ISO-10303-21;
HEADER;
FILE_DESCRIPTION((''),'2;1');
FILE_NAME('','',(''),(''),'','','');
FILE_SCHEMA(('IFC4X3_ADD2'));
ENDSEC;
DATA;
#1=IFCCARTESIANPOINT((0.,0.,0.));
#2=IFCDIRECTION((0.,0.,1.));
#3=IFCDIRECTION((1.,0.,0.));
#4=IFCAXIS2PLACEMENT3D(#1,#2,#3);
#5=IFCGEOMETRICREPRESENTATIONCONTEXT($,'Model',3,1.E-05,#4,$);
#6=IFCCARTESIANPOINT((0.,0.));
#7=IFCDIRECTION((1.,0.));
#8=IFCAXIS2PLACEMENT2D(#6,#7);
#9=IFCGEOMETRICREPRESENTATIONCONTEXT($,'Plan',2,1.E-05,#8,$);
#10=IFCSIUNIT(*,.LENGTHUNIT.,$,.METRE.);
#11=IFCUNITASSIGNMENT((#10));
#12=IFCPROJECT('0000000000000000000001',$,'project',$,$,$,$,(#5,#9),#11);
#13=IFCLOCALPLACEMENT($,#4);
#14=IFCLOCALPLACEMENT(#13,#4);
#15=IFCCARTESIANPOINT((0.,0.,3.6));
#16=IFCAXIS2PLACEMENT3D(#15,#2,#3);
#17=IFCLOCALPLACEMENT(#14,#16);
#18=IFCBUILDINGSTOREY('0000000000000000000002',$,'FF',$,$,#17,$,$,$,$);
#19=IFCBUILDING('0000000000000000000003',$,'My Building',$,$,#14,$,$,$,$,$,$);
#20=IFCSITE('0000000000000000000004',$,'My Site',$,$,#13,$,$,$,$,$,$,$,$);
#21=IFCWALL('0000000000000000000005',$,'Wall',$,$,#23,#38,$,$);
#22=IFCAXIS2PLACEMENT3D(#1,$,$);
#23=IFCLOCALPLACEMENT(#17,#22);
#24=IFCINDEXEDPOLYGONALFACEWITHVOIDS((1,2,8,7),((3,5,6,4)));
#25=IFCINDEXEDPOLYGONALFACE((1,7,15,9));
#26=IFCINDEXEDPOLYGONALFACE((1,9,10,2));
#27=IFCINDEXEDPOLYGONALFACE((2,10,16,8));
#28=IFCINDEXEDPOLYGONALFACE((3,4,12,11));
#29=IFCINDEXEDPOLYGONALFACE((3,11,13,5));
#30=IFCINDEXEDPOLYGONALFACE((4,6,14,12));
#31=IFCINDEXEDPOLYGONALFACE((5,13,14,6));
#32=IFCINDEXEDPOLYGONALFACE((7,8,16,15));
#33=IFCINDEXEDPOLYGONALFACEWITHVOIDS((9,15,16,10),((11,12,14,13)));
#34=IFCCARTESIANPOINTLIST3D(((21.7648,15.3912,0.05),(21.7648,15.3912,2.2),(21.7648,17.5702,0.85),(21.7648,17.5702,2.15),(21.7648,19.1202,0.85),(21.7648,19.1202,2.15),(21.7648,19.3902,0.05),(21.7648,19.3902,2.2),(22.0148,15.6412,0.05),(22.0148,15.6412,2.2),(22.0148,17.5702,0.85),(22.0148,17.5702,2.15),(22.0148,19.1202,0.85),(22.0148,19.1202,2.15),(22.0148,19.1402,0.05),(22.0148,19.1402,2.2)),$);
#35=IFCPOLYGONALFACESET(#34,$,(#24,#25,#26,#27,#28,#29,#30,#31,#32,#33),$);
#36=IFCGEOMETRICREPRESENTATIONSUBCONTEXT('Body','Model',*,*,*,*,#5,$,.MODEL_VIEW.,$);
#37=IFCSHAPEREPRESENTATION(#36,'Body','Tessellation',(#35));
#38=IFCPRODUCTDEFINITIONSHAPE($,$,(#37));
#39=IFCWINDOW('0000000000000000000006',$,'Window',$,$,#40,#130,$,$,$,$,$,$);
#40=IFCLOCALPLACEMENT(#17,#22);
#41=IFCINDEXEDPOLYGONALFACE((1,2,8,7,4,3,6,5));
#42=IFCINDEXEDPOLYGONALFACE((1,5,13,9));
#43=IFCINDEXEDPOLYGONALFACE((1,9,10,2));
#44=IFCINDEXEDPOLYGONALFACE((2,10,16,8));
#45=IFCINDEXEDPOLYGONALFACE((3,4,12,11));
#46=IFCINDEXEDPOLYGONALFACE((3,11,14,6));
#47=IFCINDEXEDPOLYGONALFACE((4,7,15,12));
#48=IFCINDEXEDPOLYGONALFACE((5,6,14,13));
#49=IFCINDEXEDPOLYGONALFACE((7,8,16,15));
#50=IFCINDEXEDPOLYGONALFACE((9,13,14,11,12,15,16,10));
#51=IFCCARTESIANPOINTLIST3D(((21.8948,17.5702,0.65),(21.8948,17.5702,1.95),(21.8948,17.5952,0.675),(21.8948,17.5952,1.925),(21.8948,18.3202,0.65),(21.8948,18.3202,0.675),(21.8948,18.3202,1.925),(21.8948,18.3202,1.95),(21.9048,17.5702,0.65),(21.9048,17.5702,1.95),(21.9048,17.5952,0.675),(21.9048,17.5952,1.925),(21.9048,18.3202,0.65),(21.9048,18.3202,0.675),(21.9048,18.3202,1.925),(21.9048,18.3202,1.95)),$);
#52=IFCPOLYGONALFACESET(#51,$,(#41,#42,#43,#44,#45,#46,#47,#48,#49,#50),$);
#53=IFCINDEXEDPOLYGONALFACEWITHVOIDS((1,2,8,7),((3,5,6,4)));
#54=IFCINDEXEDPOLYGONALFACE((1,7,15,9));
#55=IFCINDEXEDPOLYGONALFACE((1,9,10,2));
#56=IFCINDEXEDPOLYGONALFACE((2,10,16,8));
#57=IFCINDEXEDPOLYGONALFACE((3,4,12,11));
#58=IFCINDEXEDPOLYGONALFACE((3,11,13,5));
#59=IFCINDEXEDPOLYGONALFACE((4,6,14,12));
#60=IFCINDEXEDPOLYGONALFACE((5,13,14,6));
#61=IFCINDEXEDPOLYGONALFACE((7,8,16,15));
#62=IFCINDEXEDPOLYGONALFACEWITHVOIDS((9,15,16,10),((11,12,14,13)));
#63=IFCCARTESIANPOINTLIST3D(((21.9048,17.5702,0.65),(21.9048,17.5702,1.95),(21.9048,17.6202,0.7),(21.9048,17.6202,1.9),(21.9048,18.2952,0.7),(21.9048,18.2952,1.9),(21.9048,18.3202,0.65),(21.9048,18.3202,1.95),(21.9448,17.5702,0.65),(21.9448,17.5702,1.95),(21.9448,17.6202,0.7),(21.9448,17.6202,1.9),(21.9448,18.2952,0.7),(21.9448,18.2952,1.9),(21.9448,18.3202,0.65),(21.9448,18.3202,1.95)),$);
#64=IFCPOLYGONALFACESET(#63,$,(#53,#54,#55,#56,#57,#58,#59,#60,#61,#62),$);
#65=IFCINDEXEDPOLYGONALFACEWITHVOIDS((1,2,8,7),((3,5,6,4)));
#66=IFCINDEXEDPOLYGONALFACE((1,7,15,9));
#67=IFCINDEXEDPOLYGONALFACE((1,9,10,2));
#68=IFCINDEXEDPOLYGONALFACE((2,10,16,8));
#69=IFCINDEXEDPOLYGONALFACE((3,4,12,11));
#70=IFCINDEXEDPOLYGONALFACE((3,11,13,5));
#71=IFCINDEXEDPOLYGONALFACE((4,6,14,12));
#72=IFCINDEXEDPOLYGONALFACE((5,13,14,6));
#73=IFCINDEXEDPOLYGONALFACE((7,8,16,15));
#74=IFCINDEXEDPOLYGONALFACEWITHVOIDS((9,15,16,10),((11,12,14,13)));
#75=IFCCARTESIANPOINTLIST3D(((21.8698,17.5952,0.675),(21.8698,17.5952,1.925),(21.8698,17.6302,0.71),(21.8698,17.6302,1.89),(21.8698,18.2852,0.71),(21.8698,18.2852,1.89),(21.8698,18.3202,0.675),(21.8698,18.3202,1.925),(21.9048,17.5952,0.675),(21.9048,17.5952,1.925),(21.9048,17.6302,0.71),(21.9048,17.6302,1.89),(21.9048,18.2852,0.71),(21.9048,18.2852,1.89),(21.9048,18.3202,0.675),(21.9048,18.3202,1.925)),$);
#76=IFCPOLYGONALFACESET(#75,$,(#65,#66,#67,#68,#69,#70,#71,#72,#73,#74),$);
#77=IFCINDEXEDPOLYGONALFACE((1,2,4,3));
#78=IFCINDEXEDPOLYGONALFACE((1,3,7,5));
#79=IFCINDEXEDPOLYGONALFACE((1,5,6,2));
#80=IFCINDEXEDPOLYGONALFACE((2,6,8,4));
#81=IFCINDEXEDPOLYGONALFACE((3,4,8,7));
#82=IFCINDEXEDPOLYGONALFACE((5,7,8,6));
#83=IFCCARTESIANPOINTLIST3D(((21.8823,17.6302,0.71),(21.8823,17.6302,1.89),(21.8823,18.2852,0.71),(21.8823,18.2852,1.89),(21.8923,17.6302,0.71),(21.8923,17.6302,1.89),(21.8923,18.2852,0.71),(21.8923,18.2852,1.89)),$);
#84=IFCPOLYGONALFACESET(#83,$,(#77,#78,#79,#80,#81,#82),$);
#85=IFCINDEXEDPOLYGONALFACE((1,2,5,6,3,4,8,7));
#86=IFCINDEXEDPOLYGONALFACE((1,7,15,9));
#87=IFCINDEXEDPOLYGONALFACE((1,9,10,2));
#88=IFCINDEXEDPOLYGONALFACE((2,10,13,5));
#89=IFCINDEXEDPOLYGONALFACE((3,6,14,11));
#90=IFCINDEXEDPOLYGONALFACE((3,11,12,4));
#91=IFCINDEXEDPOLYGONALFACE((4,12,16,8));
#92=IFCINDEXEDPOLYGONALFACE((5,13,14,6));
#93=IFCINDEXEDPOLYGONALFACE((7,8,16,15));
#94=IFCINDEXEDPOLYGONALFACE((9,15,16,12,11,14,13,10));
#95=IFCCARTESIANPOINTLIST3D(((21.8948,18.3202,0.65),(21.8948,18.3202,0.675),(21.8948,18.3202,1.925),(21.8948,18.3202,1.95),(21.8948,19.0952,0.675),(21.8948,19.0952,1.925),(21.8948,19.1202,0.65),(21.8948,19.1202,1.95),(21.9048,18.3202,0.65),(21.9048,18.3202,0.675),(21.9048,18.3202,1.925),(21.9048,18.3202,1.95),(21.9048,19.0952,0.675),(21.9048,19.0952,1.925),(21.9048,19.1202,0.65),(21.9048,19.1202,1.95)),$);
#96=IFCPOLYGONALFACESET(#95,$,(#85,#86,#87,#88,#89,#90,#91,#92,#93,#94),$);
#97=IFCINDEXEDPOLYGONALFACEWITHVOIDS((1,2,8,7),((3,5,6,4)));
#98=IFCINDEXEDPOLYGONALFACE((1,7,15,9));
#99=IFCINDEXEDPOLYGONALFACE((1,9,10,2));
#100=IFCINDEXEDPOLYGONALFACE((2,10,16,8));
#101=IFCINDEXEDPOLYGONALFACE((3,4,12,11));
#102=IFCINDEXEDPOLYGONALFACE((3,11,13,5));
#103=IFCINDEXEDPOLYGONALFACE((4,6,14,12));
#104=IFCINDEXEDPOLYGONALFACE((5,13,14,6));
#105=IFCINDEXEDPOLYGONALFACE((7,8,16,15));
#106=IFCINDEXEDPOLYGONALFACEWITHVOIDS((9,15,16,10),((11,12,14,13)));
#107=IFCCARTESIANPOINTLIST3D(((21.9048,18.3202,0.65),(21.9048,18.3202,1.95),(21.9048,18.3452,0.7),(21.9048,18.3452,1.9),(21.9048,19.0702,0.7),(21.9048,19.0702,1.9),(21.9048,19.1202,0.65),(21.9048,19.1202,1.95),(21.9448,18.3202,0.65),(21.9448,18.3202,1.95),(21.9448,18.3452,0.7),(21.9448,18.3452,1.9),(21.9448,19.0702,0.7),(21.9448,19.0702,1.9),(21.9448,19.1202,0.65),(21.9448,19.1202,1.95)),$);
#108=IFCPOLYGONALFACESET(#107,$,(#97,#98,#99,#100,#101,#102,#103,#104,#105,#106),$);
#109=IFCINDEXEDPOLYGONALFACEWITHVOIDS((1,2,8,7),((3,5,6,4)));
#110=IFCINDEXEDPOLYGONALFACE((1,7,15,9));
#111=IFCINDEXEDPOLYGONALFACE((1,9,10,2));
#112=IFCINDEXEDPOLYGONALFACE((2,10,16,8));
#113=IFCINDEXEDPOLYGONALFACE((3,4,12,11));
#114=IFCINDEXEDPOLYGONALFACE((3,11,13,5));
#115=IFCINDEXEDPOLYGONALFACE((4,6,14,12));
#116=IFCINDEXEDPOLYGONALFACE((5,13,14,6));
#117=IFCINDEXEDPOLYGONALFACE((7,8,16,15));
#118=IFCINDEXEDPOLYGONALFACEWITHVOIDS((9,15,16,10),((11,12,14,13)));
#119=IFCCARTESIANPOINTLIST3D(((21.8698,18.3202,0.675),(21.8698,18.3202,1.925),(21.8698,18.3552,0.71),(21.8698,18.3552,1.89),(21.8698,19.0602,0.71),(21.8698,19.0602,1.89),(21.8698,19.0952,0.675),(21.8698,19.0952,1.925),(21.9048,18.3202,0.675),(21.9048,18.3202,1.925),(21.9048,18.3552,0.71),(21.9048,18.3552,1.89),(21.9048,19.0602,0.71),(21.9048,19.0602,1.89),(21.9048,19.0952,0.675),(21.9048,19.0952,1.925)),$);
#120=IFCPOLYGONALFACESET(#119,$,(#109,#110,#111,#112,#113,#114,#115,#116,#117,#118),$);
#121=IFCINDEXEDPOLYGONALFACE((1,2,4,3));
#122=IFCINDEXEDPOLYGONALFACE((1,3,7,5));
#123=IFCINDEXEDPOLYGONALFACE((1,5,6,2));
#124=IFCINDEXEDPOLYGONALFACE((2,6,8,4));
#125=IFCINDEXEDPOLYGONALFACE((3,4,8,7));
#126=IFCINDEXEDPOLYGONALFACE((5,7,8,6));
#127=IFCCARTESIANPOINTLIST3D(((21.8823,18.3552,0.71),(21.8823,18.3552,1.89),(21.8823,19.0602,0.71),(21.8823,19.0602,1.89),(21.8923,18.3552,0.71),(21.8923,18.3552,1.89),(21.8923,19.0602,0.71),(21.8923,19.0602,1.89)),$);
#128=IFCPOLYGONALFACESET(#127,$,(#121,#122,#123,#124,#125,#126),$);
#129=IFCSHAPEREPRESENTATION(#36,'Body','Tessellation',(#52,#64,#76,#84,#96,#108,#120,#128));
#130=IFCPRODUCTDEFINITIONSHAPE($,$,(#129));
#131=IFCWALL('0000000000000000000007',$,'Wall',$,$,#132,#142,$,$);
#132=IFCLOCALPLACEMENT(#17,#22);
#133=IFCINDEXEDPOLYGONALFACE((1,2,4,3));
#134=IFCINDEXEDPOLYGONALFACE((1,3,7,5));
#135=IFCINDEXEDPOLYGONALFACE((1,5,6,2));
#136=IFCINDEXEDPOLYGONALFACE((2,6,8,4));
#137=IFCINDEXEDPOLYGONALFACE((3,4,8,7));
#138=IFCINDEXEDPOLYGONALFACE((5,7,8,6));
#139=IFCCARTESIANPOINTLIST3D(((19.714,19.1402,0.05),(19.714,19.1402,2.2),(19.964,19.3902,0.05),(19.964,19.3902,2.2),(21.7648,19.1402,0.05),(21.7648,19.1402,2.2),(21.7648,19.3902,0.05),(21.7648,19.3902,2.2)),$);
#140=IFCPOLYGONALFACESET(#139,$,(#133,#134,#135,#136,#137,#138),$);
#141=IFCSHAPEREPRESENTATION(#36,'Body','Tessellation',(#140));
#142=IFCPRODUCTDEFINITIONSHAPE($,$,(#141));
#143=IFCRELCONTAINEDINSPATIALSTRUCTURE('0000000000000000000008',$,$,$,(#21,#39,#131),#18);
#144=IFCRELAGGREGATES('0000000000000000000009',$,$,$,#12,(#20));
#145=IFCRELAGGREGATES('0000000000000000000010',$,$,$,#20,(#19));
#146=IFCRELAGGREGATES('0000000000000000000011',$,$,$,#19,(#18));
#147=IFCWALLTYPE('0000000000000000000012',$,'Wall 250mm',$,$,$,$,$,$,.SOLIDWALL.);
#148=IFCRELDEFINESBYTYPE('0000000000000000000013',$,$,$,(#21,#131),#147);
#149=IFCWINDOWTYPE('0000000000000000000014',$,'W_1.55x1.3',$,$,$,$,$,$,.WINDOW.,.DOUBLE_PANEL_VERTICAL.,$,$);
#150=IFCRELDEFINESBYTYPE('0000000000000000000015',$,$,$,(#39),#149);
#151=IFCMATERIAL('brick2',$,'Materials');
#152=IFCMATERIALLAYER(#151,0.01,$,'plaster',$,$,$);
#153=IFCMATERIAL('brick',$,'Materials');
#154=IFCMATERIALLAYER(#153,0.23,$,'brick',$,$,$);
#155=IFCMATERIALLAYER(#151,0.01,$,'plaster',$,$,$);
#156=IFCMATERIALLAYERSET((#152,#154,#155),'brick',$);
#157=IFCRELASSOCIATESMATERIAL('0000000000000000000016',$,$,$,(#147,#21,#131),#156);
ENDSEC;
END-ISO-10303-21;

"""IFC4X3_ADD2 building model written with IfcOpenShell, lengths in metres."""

from ifc_helpers import new_model, entity, si_unit, frame, origin_with_axes, origin_2d_with_axis, place, context, subcontext, project, spatial, line, indexed_curve, outline, extrude, shape, source, transform, mapped, material, layer, layer_set, layer_usage, type_object, type_shapes, element, fill, save


model = new_model("IFC4X3_ADD2")

# Units and contexts
model_context = context("Model", 3, precision=1e-05, world=origin_with_axes())
plan_context = context("Plan", 2, precision=1e-05, world=origin_2d_with_axis())
body_context_1 = subcontext(model_context, "Body", "Model", "MODEL_VIEW")
body_context_2 = subcontext(plan_context, "Body", "Plan", "PLAN_VIEW")
ifc_project = project(units=[si_unit("LENGTHUNIT", "METRE")], contexts=[model_context, plan_context])

# Site, building, storey
site_placement = place(None, origin_with_axes())
site = spatial("IfcSite", under=ifc_project, at=site_placement, Name="My Site")
building_placement = place(site_placement, origin_with_axes())
building = spatial("IfcBuilding", under=site, at=building_placement, Name="My Building")
storey_placement = place(building_placement, frame((0.0, 0.0, 3.6), z_axis=(0.0, 0.0, 1.0), x_axis=(1.0, 0.0, 0.0)))
storey = spatial("IfcBuildingStorey", under=building, at=storey_placement, Name="FF")

# Shared definitions
ifc_material_1 = material(Name="brick2", Category="Materials")
ifc_layer_1 = layer(ifc_material_1, 0.01, Name="plaster")
ifc_material_2 = material(Name="brick", Category="Materials")
ifc_layer_2 = layer(ifc_material_2, 0.23, Name="brick")
ifc_layer_3 = layer(ifc_material_1, 0.01, Name="plaster")
ifc_layer_set_1 = layer_set([ifc_layer_1, ifc_layer_2, ifc_layer_3], Name="brick")
wall_type_1 = type_object("IfcWallType", Name="Wall 250mm", PredefinedType="SOLIDWALL", material=ifc_layer_set_1)

# Wall, opening, window
ifc_layer_usage_1 = layer_usage(ifc_layer_set_1, "AXIS2", "NEGATIVE", 0.0)
wall_1_placement = place(storey_placement, frame((21.7648, 15.3912, 0.05), z_axis=(0.0, 0.0, 1.0), x_axis=(0.000001, 1.0, 0.0)))
wall_1 = element("IfcWall", 1, at=wall_1_placement, inside=storey, type_object=wall_type_1, material=ifc_layer_usage_1, Name="Wall", context=body_context_1, shape_type="SweptSolid", body=[
    extrude(outline(indexed_curve([(0.25, -0.25), (0.0, 0.0), (3.999, 0.0), (3.749, -0.25)], segments=[line(1, 2, 3, 4, 1)])), origin_with_axes(), (0.0, 0.0, 1.0), 2.15),
])
shared_shape_1 = source(origin_with_axes(), body_context_1, "Body", "SweptSolid", [
    extrude(outline(indexed_curve([(0.0, 0.0), (1.55, 0.0), (1.55, 1.3), (0.0, 1.3)], segments=[line(1, 2, 3, 4, 1)])), frame((0.0, -0.6, 0.0), z_axis=(0.0, -1.0, 0.0), x_axis=(1.0, 0.0, 0.0)), (0.0, 0.0, -1.0), 1.2),
])
opening_1_placement = place(wall_1_placement, frame((2.179, 0.0, 0.8), z_axis=(0.0, 0.0, 1.0), x_axis=(1.0, 0.0, 0.0)))
opening_1 = element("IfcOpeningElement", 2, at=opening_1_placement, cuts=wall_1, PredefinedType="OPENING", context=body_context_1, shape_type="MappedRepresentation", body=[
    mapped(shared_shape_1, transform((0.0, 0.0, 0.0), x_axis=(1.0, 0.0, 0.0), y_axis=(0.0, 1.0, 0.0), z_axis=(0.0, 0.0, 1.0), scale=1.0)),
])
window_type = type_object("IfcWindowType", Name="W_1.55x1.3", PartitioningType="DOUBLE_PANEL_VERTICAL", PredefinedType="WINDOW")
shared_shape_2 = source(origin_with_axes(), body_context_1, "Body", "SweptSolid", [
    extrude(outline(indexed_curve([(0.75, 0.0), (0.0, 0.0), (0.0, 1.3), (0.75, 1.3), (0.75, 1.275), (0.025, 1.275), (0.025, 0.025), (0.75, 0.025)], segments=[line(1, 2, 3, 4, 5, 6, 7, 8, 1)])), frame((0.0, 0.09, 0.0), z_axis=(0.0, -1.0, 0.0), x_axis=(1.0, 0.0, 0.0)), (0.0, 0.0, -1.0), 0.01),
    extrude(outline(indexed_curve([(0.0, 0.0), (0.75, 0.0), (0.75, 1.3), (0.0, 1.3)], segments=[line(1, 2, 3, 4, 1)]), holes=[indexed_curve([(0.05, 0.05), (0.725, 0.05), (0.725, 1.25), (0.05, 1.25)], segments=[line(1, 2, 3, 4, 1)])]), frame((0.0, 0.05, 0.0), z_axis=(0.0, -1.0, 0.0), x_axis=(1.0, 0.0, 0.0)), (0.0, 0.0, -1.0), 0.04),
    extrude(outline(indexed_curve([(0.0, 0.0), (0.725, 0.0), (0.725, 1.25), (0.0, 1.25)], segments=[line(1, 2, 3, 4, 1)]), holes=[indexed_curve([(0.035, 0.035), (0.69, 0.035), (0.69, 1.215), (0.035, 1.215)], segments=[line(1, 2, 3, 4, 1)])]), frame((0.025, 0.09, 0.025), z_axis=(0.0, -1.0, 0.0), x_axis=(1.0, 0.0, 0.0)), (0.0, 0.0, -1.0), 0.035),
    extrude(outline(indexed_curve([(0.035, 0.035), (0.69, 0.035), (0.69, 1.215), (0.035, 1.215)], segments=[line(1, 2, 3, 4, 1)])), frame((0.025, 0.1025, 0.025), z_axis=(0.0, -1.0, 0.0), x_axis=(1.0, 0.0, 0.0)), (0.0, 0.0, -1.0), 0.01),
    extrude(outline(indexed_curve([(0.0, 1.3), (0.8, 1.3), (0.8, 0.0), (0.0, 0.0), (0.0, 0.025), (0.775, 0.025), (0.775, 1.275), (0.0, 1.275)], segments=[line(1, 2, 3, 4, 5, 6, 7, 8, 1)])), frame((0.75, 0.09, 0.0), z_axis=(0.0, -1.0, 0.0), x_axis=(1.0, 0.0, 0.0)), (0.0, 0.0, -1.0), 0.01),
    extrude(outline(indexed_curve([(0.0, 0.0), (0.8, 0.0), (0.8, 1.3), (0.0, 1.3)], segments=[line(1, 2, 3, 4, 1)]), holes=[indexed_curve([(0.025, 0.05), (0.75, 0.05), (0.75, 1.25), (0.025, 1.25)], segments=[line(1, 2, 3, 4, 1)])]), frame((0.75, 0.05, 0.0), z_axis=(0.0, -1.0, 0.0), x_axis=(1.0, 0.0, 0.0)), (0.0, 0.0, -1.0), 0.04),
    extrude(outline(indexed_curve([(0.0, 0.0), (0.775, 0.0), (0.775, 1.25), (0.0, 1.25)], segments=[line(1, 2, 3, 4, 1)]), holes=[indexed_curve([(0.035, 0.035), (0.74, 0.035), (0.74, 1.215), (0.035, 1.215)], segments=[line(1, 2, 3, 4, 1)])]), frame((0.75, 0.09, 0.025), z_axis=(0.0, -1.0, 0.0), x_axis=(1.0, 0.0, 0.0)), (0.0, 0.0, -1.0), 0.035),
    extrude(outline(indexed_curve([(0.035, 0.035), (0.74, 0.035), (0.74, 1.215), (0.035, 1.215)], segments=[line(1, 2, 3, 4, 1)])), frame((0.75, 0.1025, 0.025), z_axis=(0.0, -1.0, 0.0), x_axis=(1.0, 0.0, 0.0)), (0.0, 0.0, -1.0), 0.01),
])
shared_shape_3 = source(origin_with_axes(), body_context_2, "Body", "Curve2D", [
    entity("IfcIndexedPolyCurve", entity("IfcCartesianPointList2D", [[0.05, 0.05], [0.725, 0.05]])),
    entity("IfcIndexedPolyCurve", entity("IfcCartesianPointList2D", [[0.0, 0.1], [0.025, 0.1], [0.025, 0.09], [0.05, 0.09], [0.05, 0.05], [0.0, 0.05]]), [entity("IfcLineIndex", [1, 2, 3, 4, 5, 6, 1])]),
    entity("IfcIndexedPolyCurve", entity("IfcCartesianPointList2D", [[0.75, 0.1], [0.75, 0.1], [0.75, 0.09], [0.725, 0.09], [0.725, 0.05], [0.75, 0.05]])),
    entity("IfcIndexedPolyCurve", entity("IfcCartesianPointList2D", [[0.025, 0.09], [0.06, 0.09], [0.06, 0.125], [0.025, 0.125]]), [entity("IfcLineIndex", [1, 2, 3, 4, 1])]),
    entity("IfcIndexedPolyCurve", entity("IfcCartesianPointList2D", [[0.75, 0.09], [0.715, 0.09], [0.715, 0.125], [0.75, 0.125]]), [entity("IfcLineIndex", [1, 2, 3, 4, 1])]),
    entity("IfcIndexedPolyCurve", entity("IfcCartesianPointList2D", [[0.06, 0.09], [0.715, 0.09]])),
    entity("IfcIndexedPolyCurve", entity("IfcCartesianPointList2D", [[0.06, 0.125], [0.715, 0.125]])),
    entity("IfcIndexedPolyCurve", entity("IfcCartesianPointList2D", [[0.06, 0.1075], [0.715, 0.1075]])),
    entity("IfcIndexedPolyCurve", entity("IfcCartesianPointList2D", [[0.775, 0.05], [1.5, 0.05]])),
    entity("IfcIndexedPolyCurve", entity("IfcCartesianPointList2D", [[0.75, 0.1], [0.75, 0.1], [0.75, 0.09], [0.775, 0.09], [0.775, 0.05], [0.75, 0.05]])),
    entity("IfcIndexedPolyCurve", entity("IfcCartesianPointList2D", [[1.55, 0.1], [1.525, 0.1], [1.525, 0.09], [1.5, 0.09], [1.5, 0.05], [1.55, 0.05]]), [entity("IfcLineIndex", [1, 2, 3, 4, 5, 6, 1])]),
    entity("IfcIndexedPolyCurve", entity("IfcCartesianPointList2D", [[0.75, 0.09], [0.785, 0.09], [0.785, 0.125], [0.75, 0.125]]), [entity("IfcLineIndex", [1, 2, 3, 4, 1])]),
    entity("IfcIndexedPolyCurve", entity("IfcCartesianPointList2D", [[1.525, 0.09], [1.49, 0.09], [1.49, 0.125], [1.525, 0.125]]), [entity("IfcLineIndex", [1, 2, 3, 4, 1])]),
    entity("IfcIndexedPolyCurve", entity("IfcCartesianPointList2D", [[0.785, 0.09], [1.49, 0.09]])),
    entity("IfcIndexedPolyCurve", entity("IfcCartesianPointList2D", [[0.785, 0.125], [1.49, 0.125]])),
    entity("IfcIndexedPolyCurve", entity("IfcCartesianPointList2D", [[0.785, 0.1075], [1.49, 0.1075]])),
])
type_shapes(window_type, [shared_shape_2, shared_shape_3])
window_placement = place(opening_1_placement, frame((0.0, -0.23, -0.2), z_axis=(0.0, 0.0, 1.0), x_axis=(1.0, 0.0, 0.0)))
window = element("IfcWindow", 3, at=window_placement, inside=storey, type_object=window_type, Name="Window", shapes=[
    shape(body_context_1, "Body", "MappedRepresentation", [mapped(shared_shape_2, transform((0.0, 0.0, 0.0), x_axis=(1.0, 0.0, 0.0), y_axis=(0.0, 1.0, 0.0), z_axis=(0.0, 0.0, 1.0), scale=1.0))]),
    shape(body_context_2, "Body", "MappedRepresentation", [mapped(shared_shape_3, transform((0.0, 0.0, 0.0), x_axis=(1.0, 0.0, 0.0), y_axis=(0.0, 1.0, 0.0), z_axis=(0.0, 0.0, 1.0), scale=1.0))]),
])
fill(opening_1, window)

# Wall
ifc_layer_usage_2 = layer_usage(ifc_layer_set_1, "AXIS2", "NEGATIVE", 0.0)
wall_2_placement = place(storey_placement, frame((21.7648, 19.1402, 0.05), z_axis=(0.0, 0.0, 1.0), x_axis=(-1.0, 0.0, 0.0)))
element("IfcWall", 4, at=wall_2_placement, inside=storey, type_object=wall_type_1, material=ifc_layer_usage_2, Name="Wall", context=body_context_1, shape_type="SweptSolid", body=[
    extrude(outline(indexed_curve([(0.0, -0.25), (0.0, 0.0), (2.0508, 0.0), (1.8008, -0.25)], segments=[line(1, 2, 3, 4, 1)])), origin_with_axes(), (0.0, 0.0, 1.0), 2.15),
])

save(model, "model.ifc")
